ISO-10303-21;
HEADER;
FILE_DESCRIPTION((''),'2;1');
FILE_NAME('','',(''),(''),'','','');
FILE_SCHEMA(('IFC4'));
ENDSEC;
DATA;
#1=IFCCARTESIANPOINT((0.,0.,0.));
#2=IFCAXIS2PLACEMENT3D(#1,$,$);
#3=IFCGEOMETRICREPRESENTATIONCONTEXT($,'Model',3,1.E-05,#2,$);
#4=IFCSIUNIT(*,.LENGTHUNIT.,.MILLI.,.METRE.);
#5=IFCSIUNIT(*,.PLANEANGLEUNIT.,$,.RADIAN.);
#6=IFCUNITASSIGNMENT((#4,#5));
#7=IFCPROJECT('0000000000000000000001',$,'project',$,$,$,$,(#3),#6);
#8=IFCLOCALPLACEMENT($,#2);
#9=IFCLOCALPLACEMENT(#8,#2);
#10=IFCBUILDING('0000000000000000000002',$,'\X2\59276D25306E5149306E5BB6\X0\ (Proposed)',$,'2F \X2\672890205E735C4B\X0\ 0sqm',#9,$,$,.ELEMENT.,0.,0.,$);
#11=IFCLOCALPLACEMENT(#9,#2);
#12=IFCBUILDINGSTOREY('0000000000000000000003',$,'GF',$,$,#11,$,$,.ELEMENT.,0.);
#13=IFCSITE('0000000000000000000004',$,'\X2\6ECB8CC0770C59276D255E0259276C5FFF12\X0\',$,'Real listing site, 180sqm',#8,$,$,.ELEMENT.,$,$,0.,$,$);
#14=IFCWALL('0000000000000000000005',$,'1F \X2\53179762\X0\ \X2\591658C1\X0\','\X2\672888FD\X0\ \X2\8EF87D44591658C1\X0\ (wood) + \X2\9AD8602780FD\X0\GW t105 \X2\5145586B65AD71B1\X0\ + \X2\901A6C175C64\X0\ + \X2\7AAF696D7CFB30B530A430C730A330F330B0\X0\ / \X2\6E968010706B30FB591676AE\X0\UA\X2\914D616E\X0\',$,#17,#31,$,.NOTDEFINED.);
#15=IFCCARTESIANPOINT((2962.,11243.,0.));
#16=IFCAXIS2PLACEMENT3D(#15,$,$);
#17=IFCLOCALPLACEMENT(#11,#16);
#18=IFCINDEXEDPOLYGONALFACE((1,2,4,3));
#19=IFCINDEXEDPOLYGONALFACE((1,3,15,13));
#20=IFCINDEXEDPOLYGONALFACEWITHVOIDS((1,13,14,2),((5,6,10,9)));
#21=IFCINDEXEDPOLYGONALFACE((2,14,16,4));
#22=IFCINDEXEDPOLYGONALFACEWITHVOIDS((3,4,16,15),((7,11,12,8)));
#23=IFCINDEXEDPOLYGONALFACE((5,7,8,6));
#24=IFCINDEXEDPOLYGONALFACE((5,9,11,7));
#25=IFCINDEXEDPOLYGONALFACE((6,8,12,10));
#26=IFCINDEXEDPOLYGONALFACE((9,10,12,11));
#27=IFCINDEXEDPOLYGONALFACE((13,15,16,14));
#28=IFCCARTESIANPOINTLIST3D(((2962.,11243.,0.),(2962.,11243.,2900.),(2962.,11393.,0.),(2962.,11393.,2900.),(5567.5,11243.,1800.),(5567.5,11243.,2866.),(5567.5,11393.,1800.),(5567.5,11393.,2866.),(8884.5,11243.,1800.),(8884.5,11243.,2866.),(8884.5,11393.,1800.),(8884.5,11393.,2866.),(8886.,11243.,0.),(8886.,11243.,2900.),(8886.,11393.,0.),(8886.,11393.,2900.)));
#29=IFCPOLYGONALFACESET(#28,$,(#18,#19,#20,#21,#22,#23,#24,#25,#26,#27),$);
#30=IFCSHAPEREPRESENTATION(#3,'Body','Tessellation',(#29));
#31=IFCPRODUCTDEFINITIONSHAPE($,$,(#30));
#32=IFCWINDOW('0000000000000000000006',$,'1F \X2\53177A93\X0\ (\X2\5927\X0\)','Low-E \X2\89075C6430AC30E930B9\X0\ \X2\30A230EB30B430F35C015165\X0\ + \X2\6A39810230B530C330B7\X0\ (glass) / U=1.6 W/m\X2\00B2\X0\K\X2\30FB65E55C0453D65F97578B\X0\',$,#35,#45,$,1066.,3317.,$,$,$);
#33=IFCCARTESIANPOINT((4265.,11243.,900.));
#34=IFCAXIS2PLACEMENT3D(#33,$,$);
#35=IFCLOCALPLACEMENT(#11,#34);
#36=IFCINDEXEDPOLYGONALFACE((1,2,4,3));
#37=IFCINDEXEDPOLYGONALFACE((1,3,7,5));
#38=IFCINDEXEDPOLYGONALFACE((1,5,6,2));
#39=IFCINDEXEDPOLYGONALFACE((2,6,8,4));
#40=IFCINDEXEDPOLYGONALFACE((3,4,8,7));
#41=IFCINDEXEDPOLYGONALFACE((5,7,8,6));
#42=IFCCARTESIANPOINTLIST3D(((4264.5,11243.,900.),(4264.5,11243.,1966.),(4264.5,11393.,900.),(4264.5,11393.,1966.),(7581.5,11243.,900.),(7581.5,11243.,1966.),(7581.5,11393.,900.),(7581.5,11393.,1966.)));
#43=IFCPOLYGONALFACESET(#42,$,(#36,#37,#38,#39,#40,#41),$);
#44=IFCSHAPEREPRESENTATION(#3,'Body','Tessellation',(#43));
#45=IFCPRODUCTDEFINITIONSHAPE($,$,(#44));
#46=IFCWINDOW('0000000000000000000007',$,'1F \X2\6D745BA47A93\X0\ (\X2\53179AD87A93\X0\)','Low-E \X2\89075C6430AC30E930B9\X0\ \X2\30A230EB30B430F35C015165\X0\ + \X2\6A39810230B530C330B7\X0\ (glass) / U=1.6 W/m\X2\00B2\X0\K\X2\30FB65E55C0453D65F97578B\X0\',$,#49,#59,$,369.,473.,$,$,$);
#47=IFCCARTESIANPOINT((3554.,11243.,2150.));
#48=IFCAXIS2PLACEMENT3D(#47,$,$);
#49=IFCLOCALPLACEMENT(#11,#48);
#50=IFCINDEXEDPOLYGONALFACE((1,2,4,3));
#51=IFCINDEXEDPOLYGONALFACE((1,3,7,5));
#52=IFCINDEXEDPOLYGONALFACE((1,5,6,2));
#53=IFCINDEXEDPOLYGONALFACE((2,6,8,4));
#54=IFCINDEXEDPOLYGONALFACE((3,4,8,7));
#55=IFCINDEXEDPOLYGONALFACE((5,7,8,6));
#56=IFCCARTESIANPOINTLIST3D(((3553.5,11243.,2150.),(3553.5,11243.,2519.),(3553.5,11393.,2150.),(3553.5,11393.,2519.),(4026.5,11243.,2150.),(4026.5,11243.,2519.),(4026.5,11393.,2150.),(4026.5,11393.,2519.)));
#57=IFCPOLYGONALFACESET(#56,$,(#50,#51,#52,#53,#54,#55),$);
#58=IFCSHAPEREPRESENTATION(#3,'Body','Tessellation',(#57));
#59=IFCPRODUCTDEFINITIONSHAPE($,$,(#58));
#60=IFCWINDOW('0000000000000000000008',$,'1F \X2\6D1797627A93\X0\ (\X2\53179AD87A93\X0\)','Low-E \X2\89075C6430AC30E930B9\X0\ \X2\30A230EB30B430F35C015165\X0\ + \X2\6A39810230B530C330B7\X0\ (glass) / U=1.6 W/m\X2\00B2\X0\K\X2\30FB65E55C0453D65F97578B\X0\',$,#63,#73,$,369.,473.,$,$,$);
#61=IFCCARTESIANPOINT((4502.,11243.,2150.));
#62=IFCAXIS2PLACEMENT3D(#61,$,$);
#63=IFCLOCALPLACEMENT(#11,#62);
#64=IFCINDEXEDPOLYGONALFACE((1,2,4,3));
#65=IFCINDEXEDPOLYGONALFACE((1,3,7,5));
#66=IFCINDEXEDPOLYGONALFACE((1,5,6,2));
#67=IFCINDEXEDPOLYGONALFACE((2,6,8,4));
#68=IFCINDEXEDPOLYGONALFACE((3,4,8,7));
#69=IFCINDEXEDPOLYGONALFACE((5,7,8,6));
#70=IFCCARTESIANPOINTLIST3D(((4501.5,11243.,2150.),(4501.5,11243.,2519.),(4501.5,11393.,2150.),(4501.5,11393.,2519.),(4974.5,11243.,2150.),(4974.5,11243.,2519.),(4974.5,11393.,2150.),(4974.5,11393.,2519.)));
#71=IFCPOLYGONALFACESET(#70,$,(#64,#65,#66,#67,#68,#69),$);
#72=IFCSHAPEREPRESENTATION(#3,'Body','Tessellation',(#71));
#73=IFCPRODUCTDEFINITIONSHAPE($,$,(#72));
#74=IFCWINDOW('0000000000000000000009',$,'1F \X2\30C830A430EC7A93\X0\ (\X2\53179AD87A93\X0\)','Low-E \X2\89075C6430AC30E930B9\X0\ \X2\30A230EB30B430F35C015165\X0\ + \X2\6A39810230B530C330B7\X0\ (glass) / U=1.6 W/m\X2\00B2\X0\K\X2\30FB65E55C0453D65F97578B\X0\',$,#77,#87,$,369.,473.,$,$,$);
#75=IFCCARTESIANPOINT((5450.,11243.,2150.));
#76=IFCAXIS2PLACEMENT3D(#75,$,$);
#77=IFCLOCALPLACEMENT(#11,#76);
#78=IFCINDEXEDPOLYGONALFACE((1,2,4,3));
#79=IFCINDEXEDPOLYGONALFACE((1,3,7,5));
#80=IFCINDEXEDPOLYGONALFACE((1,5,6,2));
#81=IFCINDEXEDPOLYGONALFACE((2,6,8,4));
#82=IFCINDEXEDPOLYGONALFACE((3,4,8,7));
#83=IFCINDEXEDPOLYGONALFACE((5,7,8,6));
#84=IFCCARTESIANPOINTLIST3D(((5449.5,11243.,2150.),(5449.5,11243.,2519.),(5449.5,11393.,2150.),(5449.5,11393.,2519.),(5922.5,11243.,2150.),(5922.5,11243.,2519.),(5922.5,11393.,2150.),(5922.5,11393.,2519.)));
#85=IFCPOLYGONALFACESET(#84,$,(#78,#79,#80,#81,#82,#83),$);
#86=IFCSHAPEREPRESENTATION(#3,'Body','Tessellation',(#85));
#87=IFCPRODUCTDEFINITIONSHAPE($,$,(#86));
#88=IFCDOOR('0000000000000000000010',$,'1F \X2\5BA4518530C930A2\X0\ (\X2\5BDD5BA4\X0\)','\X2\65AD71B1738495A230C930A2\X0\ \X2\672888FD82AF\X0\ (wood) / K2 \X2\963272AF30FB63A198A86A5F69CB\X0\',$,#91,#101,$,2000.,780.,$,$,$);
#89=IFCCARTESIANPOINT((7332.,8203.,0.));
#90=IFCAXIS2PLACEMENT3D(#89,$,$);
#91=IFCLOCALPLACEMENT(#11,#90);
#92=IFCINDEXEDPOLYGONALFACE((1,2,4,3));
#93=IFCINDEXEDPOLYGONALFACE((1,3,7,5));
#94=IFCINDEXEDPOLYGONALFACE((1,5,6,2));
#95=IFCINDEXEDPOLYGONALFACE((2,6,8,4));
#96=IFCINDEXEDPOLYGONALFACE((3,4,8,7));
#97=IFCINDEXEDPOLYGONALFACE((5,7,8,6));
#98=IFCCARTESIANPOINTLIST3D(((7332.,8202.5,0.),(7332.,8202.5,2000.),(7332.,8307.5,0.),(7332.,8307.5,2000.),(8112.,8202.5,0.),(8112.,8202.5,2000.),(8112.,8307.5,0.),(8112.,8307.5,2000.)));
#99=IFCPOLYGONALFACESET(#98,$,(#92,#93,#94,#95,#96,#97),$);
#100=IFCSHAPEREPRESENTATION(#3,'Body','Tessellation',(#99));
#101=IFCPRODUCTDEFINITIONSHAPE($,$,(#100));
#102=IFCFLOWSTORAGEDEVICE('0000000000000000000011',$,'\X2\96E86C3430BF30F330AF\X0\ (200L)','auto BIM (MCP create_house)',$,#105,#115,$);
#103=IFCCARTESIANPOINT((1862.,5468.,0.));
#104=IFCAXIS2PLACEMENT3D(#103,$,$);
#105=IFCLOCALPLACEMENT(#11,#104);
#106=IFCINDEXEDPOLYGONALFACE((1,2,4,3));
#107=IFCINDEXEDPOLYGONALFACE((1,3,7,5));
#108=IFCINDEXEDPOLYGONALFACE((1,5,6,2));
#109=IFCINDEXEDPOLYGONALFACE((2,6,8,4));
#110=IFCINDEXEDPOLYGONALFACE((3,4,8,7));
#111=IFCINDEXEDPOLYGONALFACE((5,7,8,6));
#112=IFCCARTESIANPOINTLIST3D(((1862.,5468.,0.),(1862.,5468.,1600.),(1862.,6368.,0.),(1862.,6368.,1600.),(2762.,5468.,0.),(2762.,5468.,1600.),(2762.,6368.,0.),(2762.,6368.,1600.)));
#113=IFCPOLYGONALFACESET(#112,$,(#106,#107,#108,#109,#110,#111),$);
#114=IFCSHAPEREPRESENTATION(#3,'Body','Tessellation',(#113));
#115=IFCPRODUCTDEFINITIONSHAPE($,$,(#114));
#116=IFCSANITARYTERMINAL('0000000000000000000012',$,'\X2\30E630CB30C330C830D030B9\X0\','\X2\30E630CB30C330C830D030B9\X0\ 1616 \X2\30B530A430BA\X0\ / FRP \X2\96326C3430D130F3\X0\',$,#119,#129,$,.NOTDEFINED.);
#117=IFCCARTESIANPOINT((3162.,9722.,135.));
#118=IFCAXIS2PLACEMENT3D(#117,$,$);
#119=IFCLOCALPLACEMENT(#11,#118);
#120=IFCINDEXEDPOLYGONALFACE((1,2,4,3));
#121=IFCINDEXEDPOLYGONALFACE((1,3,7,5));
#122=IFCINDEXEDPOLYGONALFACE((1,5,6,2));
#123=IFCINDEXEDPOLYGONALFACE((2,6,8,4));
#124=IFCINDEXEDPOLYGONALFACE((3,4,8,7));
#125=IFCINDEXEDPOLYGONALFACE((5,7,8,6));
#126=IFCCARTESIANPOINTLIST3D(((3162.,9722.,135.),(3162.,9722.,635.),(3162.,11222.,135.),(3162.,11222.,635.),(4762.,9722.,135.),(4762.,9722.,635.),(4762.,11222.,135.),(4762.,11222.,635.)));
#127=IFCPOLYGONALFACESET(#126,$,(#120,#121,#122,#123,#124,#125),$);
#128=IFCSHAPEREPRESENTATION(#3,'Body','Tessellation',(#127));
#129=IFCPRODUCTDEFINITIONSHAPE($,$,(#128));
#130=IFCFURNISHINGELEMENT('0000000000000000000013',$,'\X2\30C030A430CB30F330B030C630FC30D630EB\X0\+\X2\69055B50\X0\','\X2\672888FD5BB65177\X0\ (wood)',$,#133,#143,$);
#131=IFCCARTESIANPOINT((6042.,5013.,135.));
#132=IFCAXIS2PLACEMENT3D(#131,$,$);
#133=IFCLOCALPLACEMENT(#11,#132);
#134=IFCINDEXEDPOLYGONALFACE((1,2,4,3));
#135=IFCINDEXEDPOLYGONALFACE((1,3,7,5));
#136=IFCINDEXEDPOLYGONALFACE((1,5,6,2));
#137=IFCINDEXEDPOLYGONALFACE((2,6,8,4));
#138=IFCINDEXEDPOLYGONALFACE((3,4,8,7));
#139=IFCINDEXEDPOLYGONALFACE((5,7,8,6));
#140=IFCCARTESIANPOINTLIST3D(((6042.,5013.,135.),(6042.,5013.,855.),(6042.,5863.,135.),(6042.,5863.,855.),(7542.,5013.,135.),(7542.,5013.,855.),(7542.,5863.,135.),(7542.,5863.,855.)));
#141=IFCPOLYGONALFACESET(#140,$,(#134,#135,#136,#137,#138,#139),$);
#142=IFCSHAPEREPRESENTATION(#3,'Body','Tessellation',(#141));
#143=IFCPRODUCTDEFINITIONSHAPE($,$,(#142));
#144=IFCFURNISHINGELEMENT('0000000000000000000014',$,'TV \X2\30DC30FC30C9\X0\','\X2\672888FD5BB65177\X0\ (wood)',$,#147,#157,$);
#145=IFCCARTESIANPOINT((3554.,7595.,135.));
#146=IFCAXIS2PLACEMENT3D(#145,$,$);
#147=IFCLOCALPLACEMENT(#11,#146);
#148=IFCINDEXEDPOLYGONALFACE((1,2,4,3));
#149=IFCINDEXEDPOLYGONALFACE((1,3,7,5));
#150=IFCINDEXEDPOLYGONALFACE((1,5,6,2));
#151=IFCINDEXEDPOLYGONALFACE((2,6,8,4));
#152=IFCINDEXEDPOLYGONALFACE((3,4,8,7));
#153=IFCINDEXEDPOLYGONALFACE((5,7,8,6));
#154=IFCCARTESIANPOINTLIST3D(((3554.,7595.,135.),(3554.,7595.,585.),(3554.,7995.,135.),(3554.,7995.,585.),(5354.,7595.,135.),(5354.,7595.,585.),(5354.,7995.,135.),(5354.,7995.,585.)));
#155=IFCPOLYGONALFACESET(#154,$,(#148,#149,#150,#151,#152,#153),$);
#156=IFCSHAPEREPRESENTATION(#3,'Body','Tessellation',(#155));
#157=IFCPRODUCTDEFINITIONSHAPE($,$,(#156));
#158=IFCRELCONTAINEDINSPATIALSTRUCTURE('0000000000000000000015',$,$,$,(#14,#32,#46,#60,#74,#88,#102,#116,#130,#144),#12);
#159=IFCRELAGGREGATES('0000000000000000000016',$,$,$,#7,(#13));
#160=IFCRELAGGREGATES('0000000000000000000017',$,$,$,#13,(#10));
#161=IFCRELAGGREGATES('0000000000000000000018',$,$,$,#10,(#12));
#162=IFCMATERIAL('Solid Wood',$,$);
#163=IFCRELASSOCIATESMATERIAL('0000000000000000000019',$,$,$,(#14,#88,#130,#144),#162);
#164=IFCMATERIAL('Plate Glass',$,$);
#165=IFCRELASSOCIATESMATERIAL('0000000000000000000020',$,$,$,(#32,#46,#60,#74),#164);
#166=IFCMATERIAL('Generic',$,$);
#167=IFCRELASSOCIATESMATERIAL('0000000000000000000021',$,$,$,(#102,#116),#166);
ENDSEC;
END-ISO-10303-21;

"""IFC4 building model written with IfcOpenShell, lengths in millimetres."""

from ifc_helpers import new_model, si_unit, frame, frame_2d, origin, place, context, project, spatial, rectangle, extrude, material, element, fill, save


model = new_model("IFC4")

# Units and contexts
model_context = context("Model", 3, precision=1e-05, world=origin())
ifc_project = project(units=[si_unit("LENGTHUNIT", "METRE", prefix="MILLI"), si_unit("PLANEANGLEUNIT", "RADIAN")], contexts=[model_context])

# Site, building, storey
site_placement = place(None, origin())
site = spatial("IfcSite", under=ifc_project, at=site_placement, Name="滋賀県大津市大江２", ObjectType="Real listing site, 180sqm", CompositionType="ELEMENT", RefElevation=0.0)
building_placement = place(site_placement, origin())
building = spatial("IfcBuilding", under=site, at=building_placement, Name="大津の光の家 (Proposed)", ObjectType="2F 木造平屋 0sqm", CompositionType="ELEMENT", ElevationOfRefHeight=0.0, ElevationOfTerrain=0.0)
storey_placement = place(building_placement, origin())
storey = spatial("IfcBuildingStorey", under=building, at=storey_placement, Name="GF", CompositionType="ELEMENT", Elevation=0.0)

# Wall, openings, windows
ifc_material_1 = material(Name="Solid Wood")
wall_1_placement = place(storey_placement, frame((2962.0, 11243.0, 0.0)))
wall_1 = element("IfcWall", 1, at=wall_1_placement, inside=storey, material=ifc_material_1, Name="1F 北面 外壁", Description="木製 軸組外壁 (wood) + 高性能GW t105 充填断熱 + 通気層 + 窯業系サイディング / 準耐火・外皮UA配慮", PredefinedType="NOTDEFINED", context=model_context, shape_type="SweptSolid", body=[
    extrude(rectangle(XDim=5924.0, YDim=150.0, at=frame_2d((2962.0, 75.0))), frame((2962.0, 11243.0, 0.0)), (0.0, 0.0, 1.0), 2900.0),
])
opening_1_placement = place(storey_placement, frame((4265.0, 11243.0, 900.0)))
opening_1 = element("IfcOpeningElement", 2, at=opening_1_placement, cuts=wall_1, PredefinedType="NOTDEFINED", context=model_context, shape_type="SweptSolid", body=[
    extrude(rectangle(XDim=3317.0, YDim=150.0, at=frame_2d((1658.0, 75.0))), frame((4265.0, 11243.0, 900.0)), (0.0, 0.0, 1.0), 1066.0),
])
opening_2_placement = place(storey_placement, frame((3554.0, 11243.0, 2150.0)))
opening_2 = element("IfcOpeningElement", 3, at=opening_2_placement, cuts=wall_1, PredefinedType="NOTDEFINED", context=model_context, shape_type="SweptSolid", body=[
    extrude(rectangle(XDim=473.0, YDim=150.0, at=frame_2d((236.0, 75.0))), frame((3554.0, 11243.0, 2150.0)), (0.0, 0.0, 1.0), 369.0),
])
opening_3_placement = place(storey_placement, frame((4502.0, 11243.0, 2150.0)))
opening_3 = element("IfcOpeningElement", 4, at=opening_3_placement, cuts=wall_1, PredefinedType="NOTDEFINED", context=model_context, shape_type="SweptSolid", body=[
    extrude(rectangle(XDim=473.0, YDim=150.0, at=frame_2d((236.0, 75.0))), frame((4502.0, 11243.0, 2150.0)), (0.0, 0.0, 1.0), 369.0),
])
opening_4_placement = place(storey_placement, frame((5450.0, 11243.0, 2150.0)))
opening_4 = element("IfcOpeningElement", 5, at=opening_4_placement, cuts=wall_1, PredefinedType="NOTDEFINED", context=model_context, shape_type="SweptSolid", body=[
    extrude(rectangle(XDim=473.0, YDim=150.0, at=frame_2d((236.0, 75.0))), frame((5450.0, 11243.0, 2150.0)), (0.0, 0.0, 1.0), 369.0),
])
ifc_material_2 = material(Name="Plate Glass")
window_1_placement = place(storey_placement, frame((4265.0, 11243.0, 900.0)))
window_1 = element("IfcWindow", 6, at=window_1_placement, inside=storey, material=ifc_material_2, Name="1F 北窓 (大)", Description="Low-E 複層ガラス アルゴン封入 + 樹脂サッシ (glass) / U=1.6 W/m²K・日射取得型", OverallHeight=1066.0, OverallWidth=3317.0, context=model_context, shape_type="SweptSolid", body=[
    extrude(rectangle(XDim=3317.0, YDim=150.0, at=frame_2d((1658.0, 75.0))), frame((4265.0, 11243.0, 900.0)), (0.0, 0.0, 1.0), 1066.0),
])
fill(opening_1, window_1)
window_2_placement = place(storey_placement, frame((3554.0, 11243.0, 2150.0)))
window_2 = element("IfcWindow", 7, at=window_2_placement, inside=storey, material=ifc_material_2, Name="1F 浴室窓 (北高窓)", Description="Low-E 複層ガラス アルゴン封入 + 樹脂サッシ (glass) / U=1.6 W/m²K・日射取得型", OverallHeight=369.0, OverallWidth=473.0, context=model_context, shape_type="SweptSolid", body=[
    extrude(rectangle(XDim=473.0, YDim=150.0, at=frame_2d((236.0, 75.0))), frame((3554.0, 11243.0, 2150.0)), (0.0, 0.0, 1.0), 369.0),
])
fill(opening_2, window_2)
window_3_placement = place(storey_placement, frame((4502.0, 11243.0, 2150.0)))
window_3 = element("IfcWindow", 8, at=window_3_placement, inside=storey, material=ifc_material_2, Name="1F 洗面窓 (北高窓)", Description="Low-E 複層ガラス アルゴン封入 + 樹脂サッシ (glass) / U=1.6 W/m²K・日射取得型", OverallHeight=369.0, OverallWidth=473.0, context=model_context, shape_type="SweptSolid", body=[
    extrude(rectangle(XDim=473.0, YDim=150.0, at=frame_2d((236.0, 75.0))), frame((4502.0, 11243.0, 2150.0)), (0.0, 0.0, 1.0), 369.0),
])
fill(opening_3, window_3)
window_4_placement = place(storey_placement, frame((5450.0, 11243.0, 2150.0)))
window_4 = element("IfcWindow", 9, at=window_4_placement, inside=storey, material=ifc_material_2, Name="1F トイレ窓 (北高窓)", Description="Low-E 複層ガラス アルゴン封入 + 樹脂サッシ (glass) / U=1.6 W/m²K・日射取得型", OverallHeight=369.0, OverallWidth=473.0, context=model_context, shape_type="SweptSolid", body=[
    extrude(rectangle(XDim=473.0, YDim=150.0, at=frame_2d((236.0, 75.0))), frame((5450.0, 11243.0, 2150.0)), (0.0, 0.0, 1.0), 369.0),
])
fill(opening_4, window_4)

# Door
door_1_placement = place(storey_placement, frame((7332.0, 8203.0, 0.0)))
element("IfcDoor", 10, at=door_1_placement, inside=storey, material=ifc_material_1, Name="1F 室内ドア (寝室)", Description="断熱玄関ドア 木製芯 (wood) / K2 防犯・採風機構", OverallHeight=2000.0, OverallWidth=780.0, context=model_context, shape_type="SweptSolid", body=[
    extrude(rectangle(XDim=780.0, YDim=105.0, at=frame_2d((390.0, 52.0))), frame((7332.0, 8203.0, 0.0)), (0.0, 0.0, 1.0), 2000.0),
])

# Flow storage device
ifc_material_3 = material(Name="Generic")
flow_storage_device_placement = place(storey_placement, frame((1862.0, 5468.0, 0.0)))
element("IfcFlowStorageDevice", 11, at=flow_storage_device_placement, inside=storey, material=ifc_material_3, Name="雨水タンク (200L)", Description="auto BIM (MCP create_house)", context=model_context, shape_type="SweptSolid", body=[
    extrude(rectangle(XDim=900.0, YDim=900.0, at=frame_2d((450.0, 450.0))), frame((1862.0, 5468.0, 0.0)), (0.0, 0.0, 1.0), 1600.0),
])

# Sanitary terminal
sanitary_terminal_placement = place(storey_placement, frame((3162.0, 9722.0, 135.0)))
element("IfcSanitaryTerminal", 12, at=sanitary_terminal_placement, inside=storey, material=ifc_material_3, Name="ユニットバス", Description="ユニットバス 1616 サイズ / FRP 防水パン", PredefinedType="NOTDEFINED", context=model_context, shape_type="SweptSolid", body=[
    extrude(rectangle(XDim=1600.0, YDim=1500.0, at=frame_2d((800.0, 750.0))), frame((3162.0, 9722.0, 135.0)), (0.0, 0.0, 1.0), 500.0),
])

# Furnishing elements
furnishing_1_placement = place(storey_placement, frame((6042.0, 5013.0, 135.0)))
element("IfcFurnishingElement", 13, at=furnishing_1_placement, inside=storey, material=ifc_material_1, Name="ダイニングテーブル+椅子", Description="木製家具 (wood)", context=model_context, shape_type="SweptSolid", body=[
    extrude(rectangle(XDim=1500.0, YDim=850.0, at=frame_2d((750.0, 425.0))), frame((6042.0, 5013.0, 135.0)), (0.0, 0.0, 1.0), 720.0),
])
furnishing_2_placement = place(storey_placement, frame((3554.0, 7595.0, 135.0)))
element("IfcFurnishingElement", 14, at=furnishing_2_placement, inside=storey, material=ifc_material_1, Name="TV ボード", Description="木製家具 (wood)", context=model_context, shape_type="SweptSolid", body=[
    extrude(rectangle(XDim=1800.0, YDim=400.0, at=frame_2d((900.0, 200.0))), frame((3554.0, 7595.0, 135.0)), (0.0, 0.0, 1.0), 450.0),
])

save(model, "model.ifc")
